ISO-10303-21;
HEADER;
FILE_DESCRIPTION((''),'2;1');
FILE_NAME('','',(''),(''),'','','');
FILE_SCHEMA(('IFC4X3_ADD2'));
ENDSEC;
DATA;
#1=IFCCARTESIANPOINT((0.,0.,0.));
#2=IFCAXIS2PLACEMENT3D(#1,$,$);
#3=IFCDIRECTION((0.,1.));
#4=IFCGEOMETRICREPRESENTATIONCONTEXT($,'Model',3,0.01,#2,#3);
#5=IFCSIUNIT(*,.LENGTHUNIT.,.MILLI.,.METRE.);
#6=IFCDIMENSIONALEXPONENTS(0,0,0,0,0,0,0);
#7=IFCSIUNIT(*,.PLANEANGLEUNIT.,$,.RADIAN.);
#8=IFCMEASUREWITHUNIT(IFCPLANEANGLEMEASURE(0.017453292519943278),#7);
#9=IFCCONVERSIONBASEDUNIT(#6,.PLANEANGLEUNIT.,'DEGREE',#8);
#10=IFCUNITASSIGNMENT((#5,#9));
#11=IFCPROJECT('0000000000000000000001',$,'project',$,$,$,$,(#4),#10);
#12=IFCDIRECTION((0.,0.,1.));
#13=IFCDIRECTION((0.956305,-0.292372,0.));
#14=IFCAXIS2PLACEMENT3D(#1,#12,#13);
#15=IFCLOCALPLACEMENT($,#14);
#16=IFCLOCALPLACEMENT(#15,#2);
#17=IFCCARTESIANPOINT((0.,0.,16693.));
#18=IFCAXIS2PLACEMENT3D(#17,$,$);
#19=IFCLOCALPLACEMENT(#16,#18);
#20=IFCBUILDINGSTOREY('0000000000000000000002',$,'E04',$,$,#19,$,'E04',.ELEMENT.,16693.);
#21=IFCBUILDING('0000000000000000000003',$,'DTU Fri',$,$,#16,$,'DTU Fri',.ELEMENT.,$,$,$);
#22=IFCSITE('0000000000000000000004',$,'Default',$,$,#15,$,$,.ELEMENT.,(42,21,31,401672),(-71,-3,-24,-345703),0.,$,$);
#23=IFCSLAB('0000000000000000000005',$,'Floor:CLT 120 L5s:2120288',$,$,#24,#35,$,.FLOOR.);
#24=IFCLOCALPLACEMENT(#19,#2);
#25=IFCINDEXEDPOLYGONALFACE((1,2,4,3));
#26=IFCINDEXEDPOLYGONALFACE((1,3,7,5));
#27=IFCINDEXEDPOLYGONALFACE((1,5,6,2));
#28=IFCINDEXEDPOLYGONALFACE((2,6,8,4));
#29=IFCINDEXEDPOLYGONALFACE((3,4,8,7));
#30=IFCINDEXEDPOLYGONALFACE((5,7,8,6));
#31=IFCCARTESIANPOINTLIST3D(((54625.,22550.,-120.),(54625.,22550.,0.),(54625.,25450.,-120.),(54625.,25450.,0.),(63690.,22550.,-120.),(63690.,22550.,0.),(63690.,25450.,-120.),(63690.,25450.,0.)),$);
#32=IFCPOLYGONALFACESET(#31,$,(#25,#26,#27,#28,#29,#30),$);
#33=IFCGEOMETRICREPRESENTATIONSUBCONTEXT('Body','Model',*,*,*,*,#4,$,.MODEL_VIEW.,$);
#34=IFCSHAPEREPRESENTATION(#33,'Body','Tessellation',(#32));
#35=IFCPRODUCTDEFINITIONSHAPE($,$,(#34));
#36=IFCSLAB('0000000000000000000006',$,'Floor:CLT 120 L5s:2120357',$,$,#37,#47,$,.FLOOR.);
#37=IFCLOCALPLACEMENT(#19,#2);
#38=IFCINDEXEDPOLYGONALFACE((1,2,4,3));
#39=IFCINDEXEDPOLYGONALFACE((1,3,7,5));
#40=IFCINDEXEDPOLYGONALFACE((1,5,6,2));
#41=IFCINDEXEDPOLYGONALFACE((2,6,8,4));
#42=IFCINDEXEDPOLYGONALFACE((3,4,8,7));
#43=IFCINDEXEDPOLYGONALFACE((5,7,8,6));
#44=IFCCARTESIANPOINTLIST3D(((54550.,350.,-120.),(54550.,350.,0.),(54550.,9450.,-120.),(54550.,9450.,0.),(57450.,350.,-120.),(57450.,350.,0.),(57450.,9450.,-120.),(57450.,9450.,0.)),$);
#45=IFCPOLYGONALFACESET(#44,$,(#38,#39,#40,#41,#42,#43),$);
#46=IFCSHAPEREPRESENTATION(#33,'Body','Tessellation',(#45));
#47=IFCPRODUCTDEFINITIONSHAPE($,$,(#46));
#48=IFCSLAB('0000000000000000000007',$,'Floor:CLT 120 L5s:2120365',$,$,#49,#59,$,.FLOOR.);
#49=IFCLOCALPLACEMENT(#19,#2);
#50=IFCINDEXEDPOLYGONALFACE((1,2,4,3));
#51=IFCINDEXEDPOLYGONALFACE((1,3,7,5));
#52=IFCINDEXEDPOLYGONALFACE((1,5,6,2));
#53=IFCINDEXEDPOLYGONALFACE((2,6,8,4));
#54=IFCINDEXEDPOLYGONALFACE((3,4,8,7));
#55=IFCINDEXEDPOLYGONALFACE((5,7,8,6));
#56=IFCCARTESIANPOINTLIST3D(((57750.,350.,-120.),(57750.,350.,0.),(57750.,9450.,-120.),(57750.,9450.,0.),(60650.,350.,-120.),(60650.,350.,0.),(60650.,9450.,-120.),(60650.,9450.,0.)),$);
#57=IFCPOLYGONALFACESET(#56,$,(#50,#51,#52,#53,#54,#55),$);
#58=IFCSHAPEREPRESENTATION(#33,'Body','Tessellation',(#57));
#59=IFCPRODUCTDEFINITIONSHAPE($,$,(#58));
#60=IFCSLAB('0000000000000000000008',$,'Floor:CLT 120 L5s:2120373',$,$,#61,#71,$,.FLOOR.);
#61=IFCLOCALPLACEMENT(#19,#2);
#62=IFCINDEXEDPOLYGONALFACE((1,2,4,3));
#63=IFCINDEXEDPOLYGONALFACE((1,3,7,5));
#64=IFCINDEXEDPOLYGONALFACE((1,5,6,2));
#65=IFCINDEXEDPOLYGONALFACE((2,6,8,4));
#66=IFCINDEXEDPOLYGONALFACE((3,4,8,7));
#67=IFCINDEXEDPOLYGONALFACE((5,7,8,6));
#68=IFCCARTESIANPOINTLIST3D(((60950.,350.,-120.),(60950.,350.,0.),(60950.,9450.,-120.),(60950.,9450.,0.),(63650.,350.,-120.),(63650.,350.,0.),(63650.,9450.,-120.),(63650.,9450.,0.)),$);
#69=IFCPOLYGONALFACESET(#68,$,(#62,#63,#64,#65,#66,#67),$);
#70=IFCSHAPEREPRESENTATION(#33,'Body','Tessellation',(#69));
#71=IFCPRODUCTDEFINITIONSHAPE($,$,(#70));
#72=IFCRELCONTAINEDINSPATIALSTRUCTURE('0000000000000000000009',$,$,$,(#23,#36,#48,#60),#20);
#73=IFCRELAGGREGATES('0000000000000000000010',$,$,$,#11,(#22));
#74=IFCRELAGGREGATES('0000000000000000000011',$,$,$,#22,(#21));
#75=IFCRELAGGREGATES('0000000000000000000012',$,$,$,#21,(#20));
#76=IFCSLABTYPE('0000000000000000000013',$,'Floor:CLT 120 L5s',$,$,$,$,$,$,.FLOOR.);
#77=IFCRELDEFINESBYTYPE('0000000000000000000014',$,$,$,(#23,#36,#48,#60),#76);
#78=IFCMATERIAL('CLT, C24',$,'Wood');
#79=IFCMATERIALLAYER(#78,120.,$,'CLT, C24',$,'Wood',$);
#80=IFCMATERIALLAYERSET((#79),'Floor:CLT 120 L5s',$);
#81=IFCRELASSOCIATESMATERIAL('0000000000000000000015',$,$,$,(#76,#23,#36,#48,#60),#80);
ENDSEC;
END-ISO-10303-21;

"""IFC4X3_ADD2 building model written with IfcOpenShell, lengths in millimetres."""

from ifc_helpers import new_model, entity, si_unit, converted_unit, direction, frame, frame_2d, origin, origin_2d_with_axis, place, context, subcontext, project, spatial, rectangle, extrude, material, layer, layer_set, layer_usage, type_object, element, save


model = new_model("IFC4X3_ADD2")

# Units and contexts
model_context = context("Model", 3, precision=0.01, world=origin(), true_north=direction((0.0, 1.0)))
body_context = subcontext(model_context, "Body", "Model", "MODEL_VIEW")
ifc_project = project(units=[si_unit("LENGTHUNIT", "METRE", prefix="MILLI"), converted_unit("PLANEANGLEUNIT", "DEGREE", entity("IfcPlaneAngleMeasure", 0.017453292519943278), si_unit("PLANEANGLEUNIT", "RADIAN"), dimensions=[0, 0, 0, 0, 0, 0, 0])], contexts=[model_context])

# Site, building, storey
site_placement = place(None, frame((0.0, 0.0, 0.0), z_axis=(0.0, 0.0, 1.0), x_axis=(0.956305, -0.292372, 0.0)))
site = spatial("IfcSite", under=ifc_project, at=site_placement, Name="Default", CompositionType="ELEMENT", RefLatitude=(42, 21, 31, 401672), RefLongitude=(-71, -3, -24, -345703), RefElevation=0.0)
building_placement = place(site_placement, origin())
building = spatial("IfcBuilding", under=site, at=building_placement, Name="DTU Fri", LongName="DTU Fri", CompositionType="ELEMENT")
storey_placement = place(building_placement, frame((0.0, 0.0, 16693.0)))
storey = spatial("IfcBuildingStorey", under=building, at=storey_placement, Name="E04", LongName="E04", CompositionType="ELEMENT", Elevation=16693.0)

# Slabs
ifc_material = material(Name="CLT, C24", Category="Wood")
ifc_layer = layer(ifc_material, 120.0, Name="CLT, C24", Category="Wood")
ifc_layer_set = layer_set([ifc_layer], Name="Floor:CLT 120 L5s")
slab_type = type_object("IfcSlabType", Name="Floor:CLT 120 L5s", PredefinedType="FLOOR", material=ifc_layer_set)
ifc_layer_usage_1 = layer_usage(ifc_layer_set, "AXIS3", "POSITIVE", 0.0)
slab_1_placement = place(storey_placement, origin())
element("IfcSlab", 1, at=slab_1_placement, inside=storey, type_object=slab_type, material=ifc_layer_usage_1, Name="Floor:CLT 120 L5s:2120288", PredefinedType="FLOOR", context=body_context, shape_type="SweptSolid", body=[
    extrude(rectangle(XDim=2900.0, YDim=9065.0, at=frame_2d((0.0, 0.0), x_axis=(1.0, 0.0))), frame((59157.5, 24000.0, 0.0), z_axis=(0.0, 0.0, -1.0), x_axis=(0.0, 1.0, 0.0)), (0.0, 0.0, 1.0), 120.0),
])
ifc_layer_usage_2 = layer_usage(ifc_layer_set, "AXIS3", "POSITIVE", 0.0)
slab_2_placement = place(storey_placement, origin())
element("IfcSlab", 2, at=slab_2_placement, inside=storey, type_object=slab_type, material=ifc_layer_usage_2, Name="Floor:CLT 120 L5s:2120357", PredefinedType="FLOOR", context=body_context, shape_type="SweptSolid", body=[
    extrude(rectangle(XDim=9100.0, YDim=2900.0, at=frame_2d((0.0, 0.0), x_axis=(1.0, 0.0))), frame((56000.0, 4900.0, 0.0), z_axis=(0.0, 0.0, -1.0), x_axis=(0.0, 1.0, 0.0)), (0.0, 0.0, 1.0), 120.0),
])
ifc_layer_usage_3 = layer_usage(ifc_layer_set, "AXIS3", "POSITIVE", 0.0)
slab_3_placement = place(storey_placement, origin())
element("IfcSlab", 3, at=slab_3_placement, inside=storey, type_object=slab_type, material=ifc_layer_usage_3, Name="Floor:CLT 120 L5s:2120365", PredefinedType="FLOOR", context=body_context, shape_type="SweptSolid", body=[
    extrude(rectangle(XDim=9100.0, YDim=2900.0, at=origin_2d_with_axis()), frame((59200.0, 4900.0, 0.0), z_axis=(0.0, 0.0, -1.0), x_axis=(0.0, 1.0, 0.0)), (0.0, 0.0, 1.0), 120.0),
])
ifc_layer_usage_4 = layer_usage(ifc_layer_set, "AXIS3", "POSITIVE", 0.0)
slab_4_placement = place(storey_placement, origin())
element("IfcSlab", 4, at=slab_4_placement, inside=storey, type_object=slab_type, material=ifc_layer_usage_4, Name="Floor:CLT 120 L5s:2120373", PredefinedType="FLOOR", context=body_context, shape_type="SweptSolid", body=[
    extrude(rectangle(XDim=9100.0, YDim=2700.0, at=frame_2d((0.0, 0.0), x_axis=(1.0, 0.0))), frame((62300.0, 4900.0, 0.0), z_axis=(0.0, 0.0, -1.0), x_axis=(0.0, 1.0, 0.0)), (0.0, 0.0, 1.0), 120.0),
])

save(model, "model.ifc")
